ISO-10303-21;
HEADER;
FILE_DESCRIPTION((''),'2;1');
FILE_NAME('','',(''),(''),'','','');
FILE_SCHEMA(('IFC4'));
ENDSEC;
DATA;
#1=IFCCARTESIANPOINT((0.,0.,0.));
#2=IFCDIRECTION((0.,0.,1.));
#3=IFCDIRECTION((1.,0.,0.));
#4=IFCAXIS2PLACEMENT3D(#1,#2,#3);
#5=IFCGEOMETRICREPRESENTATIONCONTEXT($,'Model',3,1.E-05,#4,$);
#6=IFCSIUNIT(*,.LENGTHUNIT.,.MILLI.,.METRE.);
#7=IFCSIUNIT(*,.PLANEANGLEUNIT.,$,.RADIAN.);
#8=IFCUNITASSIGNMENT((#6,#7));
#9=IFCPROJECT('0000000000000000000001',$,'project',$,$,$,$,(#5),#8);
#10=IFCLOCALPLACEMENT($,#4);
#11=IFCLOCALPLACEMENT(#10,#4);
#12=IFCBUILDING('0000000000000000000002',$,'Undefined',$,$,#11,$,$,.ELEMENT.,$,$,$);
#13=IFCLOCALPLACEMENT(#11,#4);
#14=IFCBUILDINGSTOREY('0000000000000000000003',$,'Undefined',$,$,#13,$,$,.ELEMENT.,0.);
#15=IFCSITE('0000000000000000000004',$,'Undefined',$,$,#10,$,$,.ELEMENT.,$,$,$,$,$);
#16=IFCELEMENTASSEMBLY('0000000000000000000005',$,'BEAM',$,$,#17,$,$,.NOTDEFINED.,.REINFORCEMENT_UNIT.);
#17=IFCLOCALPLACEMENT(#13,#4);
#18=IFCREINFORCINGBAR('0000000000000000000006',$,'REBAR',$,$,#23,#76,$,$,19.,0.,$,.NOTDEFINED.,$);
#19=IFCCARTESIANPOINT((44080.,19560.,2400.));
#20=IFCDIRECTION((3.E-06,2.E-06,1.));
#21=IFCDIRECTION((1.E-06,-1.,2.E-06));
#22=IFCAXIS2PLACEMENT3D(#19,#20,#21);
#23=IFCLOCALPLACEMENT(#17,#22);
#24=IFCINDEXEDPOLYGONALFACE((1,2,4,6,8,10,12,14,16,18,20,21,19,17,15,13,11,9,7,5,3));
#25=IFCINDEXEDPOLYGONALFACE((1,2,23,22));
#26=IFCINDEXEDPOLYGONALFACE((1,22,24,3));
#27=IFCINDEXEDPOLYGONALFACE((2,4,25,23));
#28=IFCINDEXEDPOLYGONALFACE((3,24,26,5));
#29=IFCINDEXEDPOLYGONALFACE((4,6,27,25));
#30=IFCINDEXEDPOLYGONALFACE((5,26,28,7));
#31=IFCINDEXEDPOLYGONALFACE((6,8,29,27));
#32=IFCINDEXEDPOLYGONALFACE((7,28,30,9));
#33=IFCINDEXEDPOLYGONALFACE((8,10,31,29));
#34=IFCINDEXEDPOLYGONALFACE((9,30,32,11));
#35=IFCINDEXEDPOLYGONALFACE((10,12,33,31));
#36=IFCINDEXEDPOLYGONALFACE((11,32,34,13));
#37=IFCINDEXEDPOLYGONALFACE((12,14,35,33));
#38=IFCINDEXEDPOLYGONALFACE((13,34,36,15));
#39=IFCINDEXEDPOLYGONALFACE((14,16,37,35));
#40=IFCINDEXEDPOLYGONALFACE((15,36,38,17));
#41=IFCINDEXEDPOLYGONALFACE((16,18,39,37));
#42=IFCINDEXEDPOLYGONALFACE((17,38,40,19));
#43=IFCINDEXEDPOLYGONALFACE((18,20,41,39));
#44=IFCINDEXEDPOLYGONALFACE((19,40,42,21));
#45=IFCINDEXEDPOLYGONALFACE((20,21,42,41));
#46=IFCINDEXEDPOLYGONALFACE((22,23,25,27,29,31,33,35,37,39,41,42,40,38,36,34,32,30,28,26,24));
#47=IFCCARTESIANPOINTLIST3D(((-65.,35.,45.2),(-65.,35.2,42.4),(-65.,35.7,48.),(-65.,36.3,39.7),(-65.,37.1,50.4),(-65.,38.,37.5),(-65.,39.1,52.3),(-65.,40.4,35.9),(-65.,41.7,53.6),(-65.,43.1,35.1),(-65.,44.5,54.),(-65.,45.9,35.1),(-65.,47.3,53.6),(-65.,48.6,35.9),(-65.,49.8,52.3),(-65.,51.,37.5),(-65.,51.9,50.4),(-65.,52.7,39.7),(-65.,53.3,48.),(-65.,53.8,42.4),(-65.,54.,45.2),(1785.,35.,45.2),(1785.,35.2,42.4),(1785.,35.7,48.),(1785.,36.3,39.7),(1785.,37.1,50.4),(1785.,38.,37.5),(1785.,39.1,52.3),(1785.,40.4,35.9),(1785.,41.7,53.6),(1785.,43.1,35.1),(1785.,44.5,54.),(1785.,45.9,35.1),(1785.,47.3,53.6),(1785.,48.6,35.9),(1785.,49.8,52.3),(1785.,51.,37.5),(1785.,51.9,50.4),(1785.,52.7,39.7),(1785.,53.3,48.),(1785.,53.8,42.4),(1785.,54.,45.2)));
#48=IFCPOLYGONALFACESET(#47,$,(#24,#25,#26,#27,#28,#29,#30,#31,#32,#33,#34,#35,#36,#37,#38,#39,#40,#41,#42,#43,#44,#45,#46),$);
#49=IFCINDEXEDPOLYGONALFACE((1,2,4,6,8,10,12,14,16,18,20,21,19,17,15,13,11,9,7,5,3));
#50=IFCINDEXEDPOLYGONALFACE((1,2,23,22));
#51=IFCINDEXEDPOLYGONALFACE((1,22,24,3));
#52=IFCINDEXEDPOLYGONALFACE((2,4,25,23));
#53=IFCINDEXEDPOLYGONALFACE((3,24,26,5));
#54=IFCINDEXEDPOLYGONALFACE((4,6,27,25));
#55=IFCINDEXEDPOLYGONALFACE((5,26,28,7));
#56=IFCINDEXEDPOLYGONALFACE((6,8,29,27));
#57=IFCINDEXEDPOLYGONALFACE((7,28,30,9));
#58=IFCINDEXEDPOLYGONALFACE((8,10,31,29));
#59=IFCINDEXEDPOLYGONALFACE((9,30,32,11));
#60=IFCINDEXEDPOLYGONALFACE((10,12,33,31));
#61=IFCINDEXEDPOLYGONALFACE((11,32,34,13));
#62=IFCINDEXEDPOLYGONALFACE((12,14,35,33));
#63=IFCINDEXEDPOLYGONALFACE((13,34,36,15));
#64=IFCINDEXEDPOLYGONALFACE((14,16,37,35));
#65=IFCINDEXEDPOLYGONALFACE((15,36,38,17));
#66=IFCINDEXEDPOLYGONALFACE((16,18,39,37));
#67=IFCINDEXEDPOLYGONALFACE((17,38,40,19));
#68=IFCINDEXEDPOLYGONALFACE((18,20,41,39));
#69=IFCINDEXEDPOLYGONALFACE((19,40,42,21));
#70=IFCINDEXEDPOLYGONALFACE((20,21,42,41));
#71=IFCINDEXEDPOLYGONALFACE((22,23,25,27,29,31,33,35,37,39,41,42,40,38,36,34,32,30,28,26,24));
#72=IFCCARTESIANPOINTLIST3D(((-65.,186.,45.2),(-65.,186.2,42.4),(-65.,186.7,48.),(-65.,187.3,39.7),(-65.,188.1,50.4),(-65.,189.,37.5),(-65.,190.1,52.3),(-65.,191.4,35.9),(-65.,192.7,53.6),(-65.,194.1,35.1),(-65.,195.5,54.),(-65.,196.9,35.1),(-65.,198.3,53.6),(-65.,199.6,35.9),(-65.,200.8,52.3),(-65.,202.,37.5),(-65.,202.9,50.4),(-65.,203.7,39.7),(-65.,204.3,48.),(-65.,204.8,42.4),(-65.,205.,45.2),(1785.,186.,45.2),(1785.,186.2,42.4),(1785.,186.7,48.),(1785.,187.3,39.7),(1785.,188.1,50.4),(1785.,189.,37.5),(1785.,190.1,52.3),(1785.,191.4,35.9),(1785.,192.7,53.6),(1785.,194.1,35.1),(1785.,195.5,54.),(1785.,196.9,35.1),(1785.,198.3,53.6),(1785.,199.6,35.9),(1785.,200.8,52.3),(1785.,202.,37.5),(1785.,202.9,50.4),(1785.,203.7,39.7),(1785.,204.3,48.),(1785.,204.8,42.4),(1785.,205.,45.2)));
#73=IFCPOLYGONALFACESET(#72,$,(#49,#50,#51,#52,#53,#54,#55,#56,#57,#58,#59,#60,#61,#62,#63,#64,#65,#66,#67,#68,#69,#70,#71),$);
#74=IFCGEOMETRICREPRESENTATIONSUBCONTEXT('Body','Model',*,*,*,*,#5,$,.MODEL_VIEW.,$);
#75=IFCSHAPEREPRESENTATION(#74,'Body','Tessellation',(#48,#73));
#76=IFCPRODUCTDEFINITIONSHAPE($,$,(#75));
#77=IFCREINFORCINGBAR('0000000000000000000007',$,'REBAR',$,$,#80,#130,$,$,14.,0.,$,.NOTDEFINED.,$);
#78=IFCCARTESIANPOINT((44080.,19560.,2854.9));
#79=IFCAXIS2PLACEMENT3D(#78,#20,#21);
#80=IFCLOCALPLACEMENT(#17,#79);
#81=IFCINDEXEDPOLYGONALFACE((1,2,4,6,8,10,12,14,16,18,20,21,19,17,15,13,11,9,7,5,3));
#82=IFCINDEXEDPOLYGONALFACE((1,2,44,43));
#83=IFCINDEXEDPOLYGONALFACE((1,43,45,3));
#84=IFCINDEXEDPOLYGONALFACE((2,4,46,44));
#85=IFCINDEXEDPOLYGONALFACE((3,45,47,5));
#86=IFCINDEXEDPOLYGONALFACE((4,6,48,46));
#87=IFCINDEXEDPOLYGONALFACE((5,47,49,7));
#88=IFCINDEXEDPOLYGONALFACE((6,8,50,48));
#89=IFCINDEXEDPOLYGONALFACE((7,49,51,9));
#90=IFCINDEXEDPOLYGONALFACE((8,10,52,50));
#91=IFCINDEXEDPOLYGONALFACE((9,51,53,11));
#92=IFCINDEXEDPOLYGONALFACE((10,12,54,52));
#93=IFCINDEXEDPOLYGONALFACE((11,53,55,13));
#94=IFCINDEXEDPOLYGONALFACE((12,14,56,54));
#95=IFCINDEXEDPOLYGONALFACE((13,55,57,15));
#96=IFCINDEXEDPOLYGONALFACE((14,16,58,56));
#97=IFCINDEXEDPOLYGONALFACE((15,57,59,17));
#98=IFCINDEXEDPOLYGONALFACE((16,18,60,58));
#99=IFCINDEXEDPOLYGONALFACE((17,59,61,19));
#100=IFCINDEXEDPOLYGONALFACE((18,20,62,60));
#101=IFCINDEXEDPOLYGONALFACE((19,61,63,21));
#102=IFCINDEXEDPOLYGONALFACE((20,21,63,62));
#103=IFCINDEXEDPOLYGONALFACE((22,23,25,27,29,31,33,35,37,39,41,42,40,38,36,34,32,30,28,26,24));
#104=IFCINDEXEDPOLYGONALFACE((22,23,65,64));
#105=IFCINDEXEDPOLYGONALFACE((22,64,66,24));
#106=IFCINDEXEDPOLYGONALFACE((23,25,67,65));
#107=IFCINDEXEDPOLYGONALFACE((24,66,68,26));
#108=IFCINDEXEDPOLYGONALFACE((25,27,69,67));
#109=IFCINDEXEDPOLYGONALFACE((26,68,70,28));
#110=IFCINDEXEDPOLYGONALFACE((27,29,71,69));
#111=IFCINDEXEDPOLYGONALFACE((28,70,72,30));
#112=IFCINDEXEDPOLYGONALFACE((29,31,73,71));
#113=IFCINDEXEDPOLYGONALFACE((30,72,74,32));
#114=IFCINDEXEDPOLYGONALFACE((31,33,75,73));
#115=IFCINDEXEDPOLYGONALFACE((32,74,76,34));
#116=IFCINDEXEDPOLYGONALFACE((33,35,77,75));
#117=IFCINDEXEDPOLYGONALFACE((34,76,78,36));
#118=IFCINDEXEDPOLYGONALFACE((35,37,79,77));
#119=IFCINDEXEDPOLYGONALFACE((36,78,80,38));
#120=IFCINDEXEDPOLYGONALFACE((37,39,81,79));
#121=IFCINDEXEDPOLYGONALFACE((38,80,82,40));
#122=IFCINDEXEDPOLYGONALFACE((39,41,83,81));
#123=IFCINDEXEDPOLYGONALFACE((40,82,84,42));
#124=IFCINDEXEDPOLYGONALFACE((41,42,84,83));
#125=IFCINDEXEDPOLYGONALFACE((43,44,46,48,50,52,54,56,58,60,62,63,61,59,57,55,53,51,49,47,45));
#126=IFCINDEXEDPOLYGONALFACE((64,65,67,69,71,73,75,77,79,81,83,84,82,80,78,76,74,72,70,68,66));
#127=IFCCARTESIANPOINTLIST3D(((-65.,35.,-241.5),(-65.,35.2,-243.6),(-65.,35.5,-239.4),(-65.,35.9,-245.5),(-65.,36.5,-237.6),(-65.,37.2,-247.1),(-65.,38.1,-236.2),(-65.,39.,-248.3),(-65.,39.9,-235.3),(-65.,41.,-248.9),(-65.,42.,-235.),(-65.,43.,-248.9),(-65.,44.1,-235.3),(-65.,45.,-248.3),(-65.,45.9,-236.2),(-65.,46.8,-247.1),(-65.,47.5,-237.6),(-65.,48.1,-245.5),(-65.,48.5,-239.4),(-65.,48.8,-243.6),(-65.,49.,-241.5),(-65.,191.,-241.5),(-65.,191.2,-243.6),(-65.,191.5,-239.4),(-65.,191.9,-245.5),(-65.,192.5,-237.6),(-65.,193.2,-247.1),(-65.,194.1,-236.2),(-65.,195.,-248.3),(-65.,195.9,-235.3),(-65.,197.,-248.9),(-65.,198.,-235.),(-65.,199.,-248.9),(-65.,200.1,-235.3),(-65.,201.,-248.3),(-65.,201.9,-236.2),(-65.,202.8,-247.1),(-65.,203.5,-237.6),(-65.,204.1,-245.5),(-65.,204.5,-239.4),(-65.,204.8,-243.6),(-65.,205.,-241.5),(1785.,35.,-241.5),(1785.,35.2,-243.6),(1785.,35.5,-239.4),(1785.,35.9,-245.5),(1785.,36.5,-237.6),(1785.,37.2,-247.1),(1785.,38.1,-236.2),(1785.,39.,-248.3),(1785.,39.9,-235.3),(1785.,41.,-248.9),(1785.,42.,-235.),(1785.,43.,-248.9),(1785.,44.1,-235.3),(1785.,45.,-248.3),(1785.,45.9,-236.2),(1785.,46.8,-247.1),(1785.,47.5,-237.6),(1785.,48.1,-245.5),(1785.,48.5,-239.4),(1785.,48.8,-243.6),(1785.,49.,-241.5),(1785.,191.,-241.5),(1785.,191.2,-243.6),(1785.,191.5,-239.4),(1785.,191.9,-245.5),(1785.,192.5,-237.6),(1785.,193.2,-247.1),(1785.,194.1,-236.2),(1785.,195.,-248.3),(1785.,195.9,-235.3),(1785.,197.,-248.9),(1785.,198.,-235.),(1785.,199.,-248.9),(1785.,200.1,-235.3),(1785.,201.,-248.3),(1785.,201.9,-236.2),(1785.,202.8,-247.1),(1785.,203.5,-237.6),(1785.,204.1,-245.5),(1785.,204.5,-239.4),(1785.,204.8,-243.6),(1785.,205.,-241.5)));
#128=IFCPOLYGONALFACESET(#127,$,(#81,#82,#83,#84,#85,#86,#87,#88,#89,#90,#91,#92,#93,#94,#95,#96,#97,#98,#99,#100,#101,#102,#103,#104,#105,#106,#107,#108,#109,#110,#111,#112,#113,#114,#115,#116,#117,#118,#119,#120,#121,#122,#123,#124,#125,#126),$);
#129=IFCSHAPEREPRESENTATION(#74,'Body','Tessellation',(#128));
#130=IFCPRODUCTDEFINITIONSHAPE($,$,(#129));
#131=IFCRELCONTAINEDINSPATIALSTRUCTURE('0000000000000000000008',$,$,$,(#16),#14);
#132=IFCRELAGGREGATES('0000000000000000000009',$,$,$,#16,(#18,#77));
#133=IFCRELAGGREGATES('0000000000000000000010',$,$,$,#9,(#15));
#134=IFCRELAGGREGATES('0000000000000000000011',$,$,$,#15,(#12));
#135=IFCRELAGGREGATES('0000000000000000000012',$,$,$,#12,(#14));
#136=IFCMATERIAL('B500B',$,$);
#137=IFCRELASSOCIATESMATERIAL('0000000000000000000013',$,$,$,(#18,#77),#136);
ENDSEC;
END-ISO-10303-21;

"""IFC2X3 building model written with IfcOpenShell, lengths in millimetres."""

from ifc_helpers import new_model, entity, si_unit, frame, origin_with_axes, place, context, subcontext, project, spatial, source, transform, mapped, material, element, aggregate, save


model = new_model("IFC2X3")

# Units and contexts
model_context = context("Model", 3, precision=1e-05, world=origin_with_axes())
body_context = subcontext(model_context, "Body", "Model", "MODEL_VIEW")
ifc_project = project(units=[si_unit("LENGTHUNIT", "METRE", prefix="MILLI"), si_unit("PLANEANGLEUNIT", "RADIAN")], contexts=[model_context])

# Site, building, storey
site_placement = place(None, origin_with_axes())
site = spatial("IfcSite", under=ifc_project, at=site_placement, Name="Undefined", CompositionType="ELEMENT")
building_placement = place(site_placement, origin_with_axes())
building = spatial("IfcBuilding", under=site, at=building_placement, Name="Undefined", CompositionType="ELEMENT")
storey_placement = place(building_placement, origin_with_axes())
storey = spatial("IfcBuildingStorey", under=building, at=storey_placement, Name="Undefined", CompositionType="ELEMENT", Elevation=0.0)

# Element assembly
assembly_1_placement = place(storey_placement, origin_with_axes())
assembly_1 = element("IfcElementAssembly", 1, at=assembly_1_placement, inside=storey, Name="BEAM", AssemblyPlace="NOTDEFINED", PredefinedType="REINFORCEMENT_UNIT")

# Reinforcing bars
ifc_material_1 = material(Name="B500B")
shared_shape_1 = source(origin_with_axes(), body_context, "Body", "AdvancedSweptSolid", [
    entity("IfcSweptDiskSolid", entity("IfcTrimmedCurve", entity("IfcLine", entity("IfcCartesianPoint", [0.0, 0.0, 0.0]), entity("IfcVector", entity("IfcDirection", [1.0, 0.0, 0.000001]), 1.0)), [entity("IfcParameterValue", 0.0)], [entity("IfcParameterValue", 1850.009466)], True, "PARAMETER"), 9.5, None, 0.0, 1850.0),
])
shared_shape_2 = source(origin_with_axes(), body_context, "Body", "AdvancedSweptSolid", [
    entity("IfcSweptDiskSolid", entity("IfcTrimmedCurve", entity("IfcLine", entity("IfcCartesianPoint", [0.0, 0.0, 0.0]), entity("IfcVector", entity("IfcDirection", [1.0, 0.0, 0.000001]), 1.0)), [entity("IfcParameterValue", 0.0)], [entity("IfcParameterValue", 1850.009466)], True, "PARAMETER"), 9.5, None, 0.0, 1850.0),
])
reinforcing_bar_1_placement = place(assembly_1_placement, frame((44080.0, 19560.0, 2400.0), z_axis=(0.000003, 0.000002, 1.0), x_axis=(0.000001, -1.0, 0.000002)))
reinforcing_bar_1 = element("IfcReinforcingBar", 2, at=reinforcing_bar_1_placement, material=ifc_material_1, Name="REBAR", BarRole="NOTDEFINED", CrossSectionArea=0.0, NominalDiameter=19.0, context=body_context, shape_type="MappedRepresentation", body=[
    mapped(shared_shape_1, transform((-65.0, 44.5, 44.5))),
    mapped(shared_shape_2, transform((-65.0, 195.5, 44.5))),
])
shared_shape_3 = source(origin_with_axes(), body_context, "Body", "AdvancedSweptSolid", [
    entity("IfcSweptDiskSolid", entity("IfcTrimmedCurve", entity("IfcLine", entity("IfcCartesianPoint", [0.0, 0.0, 0.0]), entity("IfcVector", entity("IfcDirection", [1.0, 0.0, 0.000001]), 1.0)), [entity("IfcParameterValue", 0.0)], [entity("IfcParameterValue", 1850.009466)], True, "PARAMETER"), 7.0, None, 0.0, 1850.0),
])
shared_shape_4 = source(origin_with_axes(), body_context, "Body", "AdvancedSweptSolid", [
    entity("IfcSweptDiskSolid", entity("IfcTrimmedCurve", entity("IfcLine", entity("IfcCartesianPoint", [0.0, 0.0, 0.0]), entity("IfcVector", entity("IfcDirection", [1.0, 0.0, 0.000001]), 1.0)), [entity("IfcParameterValue", 0.0)], [entity("IfcParameterValue", 1850.009466)], True, "PARAMETER"), 7.0, None, 0.0, 1850.0),
])
reinforcing_bar_2_placement = place(assembly_1_placement, frame((44080.0, 19560.0, 2854.9), z_axis=(0.000003, 0.000002, 1.0), x_axis=(0.000001, -1.0, 0.000002)))
reinforcing_bar_2 = element("IfcReinforcingBar", 3, at=reinforcing_bar_2_placement, material=ifc_material_1, Name="REBAR", BarRole="NOTDEFINED", CrossSectionArea=0.0, NominalDiameter=14.0, context=body_context, shape_type="MappedRepresentation", body=[
    mapped(shared_shape_3, transform((-65.0, 42.0, -242.0))),
    mapped(shared_shape_4, transform((-65.0, 198.0, -242.0))),
])
aggregate(assembly_1, [reinforcing_bar_1, reinforcing_bar_2])

save(model, "model.ifc")
